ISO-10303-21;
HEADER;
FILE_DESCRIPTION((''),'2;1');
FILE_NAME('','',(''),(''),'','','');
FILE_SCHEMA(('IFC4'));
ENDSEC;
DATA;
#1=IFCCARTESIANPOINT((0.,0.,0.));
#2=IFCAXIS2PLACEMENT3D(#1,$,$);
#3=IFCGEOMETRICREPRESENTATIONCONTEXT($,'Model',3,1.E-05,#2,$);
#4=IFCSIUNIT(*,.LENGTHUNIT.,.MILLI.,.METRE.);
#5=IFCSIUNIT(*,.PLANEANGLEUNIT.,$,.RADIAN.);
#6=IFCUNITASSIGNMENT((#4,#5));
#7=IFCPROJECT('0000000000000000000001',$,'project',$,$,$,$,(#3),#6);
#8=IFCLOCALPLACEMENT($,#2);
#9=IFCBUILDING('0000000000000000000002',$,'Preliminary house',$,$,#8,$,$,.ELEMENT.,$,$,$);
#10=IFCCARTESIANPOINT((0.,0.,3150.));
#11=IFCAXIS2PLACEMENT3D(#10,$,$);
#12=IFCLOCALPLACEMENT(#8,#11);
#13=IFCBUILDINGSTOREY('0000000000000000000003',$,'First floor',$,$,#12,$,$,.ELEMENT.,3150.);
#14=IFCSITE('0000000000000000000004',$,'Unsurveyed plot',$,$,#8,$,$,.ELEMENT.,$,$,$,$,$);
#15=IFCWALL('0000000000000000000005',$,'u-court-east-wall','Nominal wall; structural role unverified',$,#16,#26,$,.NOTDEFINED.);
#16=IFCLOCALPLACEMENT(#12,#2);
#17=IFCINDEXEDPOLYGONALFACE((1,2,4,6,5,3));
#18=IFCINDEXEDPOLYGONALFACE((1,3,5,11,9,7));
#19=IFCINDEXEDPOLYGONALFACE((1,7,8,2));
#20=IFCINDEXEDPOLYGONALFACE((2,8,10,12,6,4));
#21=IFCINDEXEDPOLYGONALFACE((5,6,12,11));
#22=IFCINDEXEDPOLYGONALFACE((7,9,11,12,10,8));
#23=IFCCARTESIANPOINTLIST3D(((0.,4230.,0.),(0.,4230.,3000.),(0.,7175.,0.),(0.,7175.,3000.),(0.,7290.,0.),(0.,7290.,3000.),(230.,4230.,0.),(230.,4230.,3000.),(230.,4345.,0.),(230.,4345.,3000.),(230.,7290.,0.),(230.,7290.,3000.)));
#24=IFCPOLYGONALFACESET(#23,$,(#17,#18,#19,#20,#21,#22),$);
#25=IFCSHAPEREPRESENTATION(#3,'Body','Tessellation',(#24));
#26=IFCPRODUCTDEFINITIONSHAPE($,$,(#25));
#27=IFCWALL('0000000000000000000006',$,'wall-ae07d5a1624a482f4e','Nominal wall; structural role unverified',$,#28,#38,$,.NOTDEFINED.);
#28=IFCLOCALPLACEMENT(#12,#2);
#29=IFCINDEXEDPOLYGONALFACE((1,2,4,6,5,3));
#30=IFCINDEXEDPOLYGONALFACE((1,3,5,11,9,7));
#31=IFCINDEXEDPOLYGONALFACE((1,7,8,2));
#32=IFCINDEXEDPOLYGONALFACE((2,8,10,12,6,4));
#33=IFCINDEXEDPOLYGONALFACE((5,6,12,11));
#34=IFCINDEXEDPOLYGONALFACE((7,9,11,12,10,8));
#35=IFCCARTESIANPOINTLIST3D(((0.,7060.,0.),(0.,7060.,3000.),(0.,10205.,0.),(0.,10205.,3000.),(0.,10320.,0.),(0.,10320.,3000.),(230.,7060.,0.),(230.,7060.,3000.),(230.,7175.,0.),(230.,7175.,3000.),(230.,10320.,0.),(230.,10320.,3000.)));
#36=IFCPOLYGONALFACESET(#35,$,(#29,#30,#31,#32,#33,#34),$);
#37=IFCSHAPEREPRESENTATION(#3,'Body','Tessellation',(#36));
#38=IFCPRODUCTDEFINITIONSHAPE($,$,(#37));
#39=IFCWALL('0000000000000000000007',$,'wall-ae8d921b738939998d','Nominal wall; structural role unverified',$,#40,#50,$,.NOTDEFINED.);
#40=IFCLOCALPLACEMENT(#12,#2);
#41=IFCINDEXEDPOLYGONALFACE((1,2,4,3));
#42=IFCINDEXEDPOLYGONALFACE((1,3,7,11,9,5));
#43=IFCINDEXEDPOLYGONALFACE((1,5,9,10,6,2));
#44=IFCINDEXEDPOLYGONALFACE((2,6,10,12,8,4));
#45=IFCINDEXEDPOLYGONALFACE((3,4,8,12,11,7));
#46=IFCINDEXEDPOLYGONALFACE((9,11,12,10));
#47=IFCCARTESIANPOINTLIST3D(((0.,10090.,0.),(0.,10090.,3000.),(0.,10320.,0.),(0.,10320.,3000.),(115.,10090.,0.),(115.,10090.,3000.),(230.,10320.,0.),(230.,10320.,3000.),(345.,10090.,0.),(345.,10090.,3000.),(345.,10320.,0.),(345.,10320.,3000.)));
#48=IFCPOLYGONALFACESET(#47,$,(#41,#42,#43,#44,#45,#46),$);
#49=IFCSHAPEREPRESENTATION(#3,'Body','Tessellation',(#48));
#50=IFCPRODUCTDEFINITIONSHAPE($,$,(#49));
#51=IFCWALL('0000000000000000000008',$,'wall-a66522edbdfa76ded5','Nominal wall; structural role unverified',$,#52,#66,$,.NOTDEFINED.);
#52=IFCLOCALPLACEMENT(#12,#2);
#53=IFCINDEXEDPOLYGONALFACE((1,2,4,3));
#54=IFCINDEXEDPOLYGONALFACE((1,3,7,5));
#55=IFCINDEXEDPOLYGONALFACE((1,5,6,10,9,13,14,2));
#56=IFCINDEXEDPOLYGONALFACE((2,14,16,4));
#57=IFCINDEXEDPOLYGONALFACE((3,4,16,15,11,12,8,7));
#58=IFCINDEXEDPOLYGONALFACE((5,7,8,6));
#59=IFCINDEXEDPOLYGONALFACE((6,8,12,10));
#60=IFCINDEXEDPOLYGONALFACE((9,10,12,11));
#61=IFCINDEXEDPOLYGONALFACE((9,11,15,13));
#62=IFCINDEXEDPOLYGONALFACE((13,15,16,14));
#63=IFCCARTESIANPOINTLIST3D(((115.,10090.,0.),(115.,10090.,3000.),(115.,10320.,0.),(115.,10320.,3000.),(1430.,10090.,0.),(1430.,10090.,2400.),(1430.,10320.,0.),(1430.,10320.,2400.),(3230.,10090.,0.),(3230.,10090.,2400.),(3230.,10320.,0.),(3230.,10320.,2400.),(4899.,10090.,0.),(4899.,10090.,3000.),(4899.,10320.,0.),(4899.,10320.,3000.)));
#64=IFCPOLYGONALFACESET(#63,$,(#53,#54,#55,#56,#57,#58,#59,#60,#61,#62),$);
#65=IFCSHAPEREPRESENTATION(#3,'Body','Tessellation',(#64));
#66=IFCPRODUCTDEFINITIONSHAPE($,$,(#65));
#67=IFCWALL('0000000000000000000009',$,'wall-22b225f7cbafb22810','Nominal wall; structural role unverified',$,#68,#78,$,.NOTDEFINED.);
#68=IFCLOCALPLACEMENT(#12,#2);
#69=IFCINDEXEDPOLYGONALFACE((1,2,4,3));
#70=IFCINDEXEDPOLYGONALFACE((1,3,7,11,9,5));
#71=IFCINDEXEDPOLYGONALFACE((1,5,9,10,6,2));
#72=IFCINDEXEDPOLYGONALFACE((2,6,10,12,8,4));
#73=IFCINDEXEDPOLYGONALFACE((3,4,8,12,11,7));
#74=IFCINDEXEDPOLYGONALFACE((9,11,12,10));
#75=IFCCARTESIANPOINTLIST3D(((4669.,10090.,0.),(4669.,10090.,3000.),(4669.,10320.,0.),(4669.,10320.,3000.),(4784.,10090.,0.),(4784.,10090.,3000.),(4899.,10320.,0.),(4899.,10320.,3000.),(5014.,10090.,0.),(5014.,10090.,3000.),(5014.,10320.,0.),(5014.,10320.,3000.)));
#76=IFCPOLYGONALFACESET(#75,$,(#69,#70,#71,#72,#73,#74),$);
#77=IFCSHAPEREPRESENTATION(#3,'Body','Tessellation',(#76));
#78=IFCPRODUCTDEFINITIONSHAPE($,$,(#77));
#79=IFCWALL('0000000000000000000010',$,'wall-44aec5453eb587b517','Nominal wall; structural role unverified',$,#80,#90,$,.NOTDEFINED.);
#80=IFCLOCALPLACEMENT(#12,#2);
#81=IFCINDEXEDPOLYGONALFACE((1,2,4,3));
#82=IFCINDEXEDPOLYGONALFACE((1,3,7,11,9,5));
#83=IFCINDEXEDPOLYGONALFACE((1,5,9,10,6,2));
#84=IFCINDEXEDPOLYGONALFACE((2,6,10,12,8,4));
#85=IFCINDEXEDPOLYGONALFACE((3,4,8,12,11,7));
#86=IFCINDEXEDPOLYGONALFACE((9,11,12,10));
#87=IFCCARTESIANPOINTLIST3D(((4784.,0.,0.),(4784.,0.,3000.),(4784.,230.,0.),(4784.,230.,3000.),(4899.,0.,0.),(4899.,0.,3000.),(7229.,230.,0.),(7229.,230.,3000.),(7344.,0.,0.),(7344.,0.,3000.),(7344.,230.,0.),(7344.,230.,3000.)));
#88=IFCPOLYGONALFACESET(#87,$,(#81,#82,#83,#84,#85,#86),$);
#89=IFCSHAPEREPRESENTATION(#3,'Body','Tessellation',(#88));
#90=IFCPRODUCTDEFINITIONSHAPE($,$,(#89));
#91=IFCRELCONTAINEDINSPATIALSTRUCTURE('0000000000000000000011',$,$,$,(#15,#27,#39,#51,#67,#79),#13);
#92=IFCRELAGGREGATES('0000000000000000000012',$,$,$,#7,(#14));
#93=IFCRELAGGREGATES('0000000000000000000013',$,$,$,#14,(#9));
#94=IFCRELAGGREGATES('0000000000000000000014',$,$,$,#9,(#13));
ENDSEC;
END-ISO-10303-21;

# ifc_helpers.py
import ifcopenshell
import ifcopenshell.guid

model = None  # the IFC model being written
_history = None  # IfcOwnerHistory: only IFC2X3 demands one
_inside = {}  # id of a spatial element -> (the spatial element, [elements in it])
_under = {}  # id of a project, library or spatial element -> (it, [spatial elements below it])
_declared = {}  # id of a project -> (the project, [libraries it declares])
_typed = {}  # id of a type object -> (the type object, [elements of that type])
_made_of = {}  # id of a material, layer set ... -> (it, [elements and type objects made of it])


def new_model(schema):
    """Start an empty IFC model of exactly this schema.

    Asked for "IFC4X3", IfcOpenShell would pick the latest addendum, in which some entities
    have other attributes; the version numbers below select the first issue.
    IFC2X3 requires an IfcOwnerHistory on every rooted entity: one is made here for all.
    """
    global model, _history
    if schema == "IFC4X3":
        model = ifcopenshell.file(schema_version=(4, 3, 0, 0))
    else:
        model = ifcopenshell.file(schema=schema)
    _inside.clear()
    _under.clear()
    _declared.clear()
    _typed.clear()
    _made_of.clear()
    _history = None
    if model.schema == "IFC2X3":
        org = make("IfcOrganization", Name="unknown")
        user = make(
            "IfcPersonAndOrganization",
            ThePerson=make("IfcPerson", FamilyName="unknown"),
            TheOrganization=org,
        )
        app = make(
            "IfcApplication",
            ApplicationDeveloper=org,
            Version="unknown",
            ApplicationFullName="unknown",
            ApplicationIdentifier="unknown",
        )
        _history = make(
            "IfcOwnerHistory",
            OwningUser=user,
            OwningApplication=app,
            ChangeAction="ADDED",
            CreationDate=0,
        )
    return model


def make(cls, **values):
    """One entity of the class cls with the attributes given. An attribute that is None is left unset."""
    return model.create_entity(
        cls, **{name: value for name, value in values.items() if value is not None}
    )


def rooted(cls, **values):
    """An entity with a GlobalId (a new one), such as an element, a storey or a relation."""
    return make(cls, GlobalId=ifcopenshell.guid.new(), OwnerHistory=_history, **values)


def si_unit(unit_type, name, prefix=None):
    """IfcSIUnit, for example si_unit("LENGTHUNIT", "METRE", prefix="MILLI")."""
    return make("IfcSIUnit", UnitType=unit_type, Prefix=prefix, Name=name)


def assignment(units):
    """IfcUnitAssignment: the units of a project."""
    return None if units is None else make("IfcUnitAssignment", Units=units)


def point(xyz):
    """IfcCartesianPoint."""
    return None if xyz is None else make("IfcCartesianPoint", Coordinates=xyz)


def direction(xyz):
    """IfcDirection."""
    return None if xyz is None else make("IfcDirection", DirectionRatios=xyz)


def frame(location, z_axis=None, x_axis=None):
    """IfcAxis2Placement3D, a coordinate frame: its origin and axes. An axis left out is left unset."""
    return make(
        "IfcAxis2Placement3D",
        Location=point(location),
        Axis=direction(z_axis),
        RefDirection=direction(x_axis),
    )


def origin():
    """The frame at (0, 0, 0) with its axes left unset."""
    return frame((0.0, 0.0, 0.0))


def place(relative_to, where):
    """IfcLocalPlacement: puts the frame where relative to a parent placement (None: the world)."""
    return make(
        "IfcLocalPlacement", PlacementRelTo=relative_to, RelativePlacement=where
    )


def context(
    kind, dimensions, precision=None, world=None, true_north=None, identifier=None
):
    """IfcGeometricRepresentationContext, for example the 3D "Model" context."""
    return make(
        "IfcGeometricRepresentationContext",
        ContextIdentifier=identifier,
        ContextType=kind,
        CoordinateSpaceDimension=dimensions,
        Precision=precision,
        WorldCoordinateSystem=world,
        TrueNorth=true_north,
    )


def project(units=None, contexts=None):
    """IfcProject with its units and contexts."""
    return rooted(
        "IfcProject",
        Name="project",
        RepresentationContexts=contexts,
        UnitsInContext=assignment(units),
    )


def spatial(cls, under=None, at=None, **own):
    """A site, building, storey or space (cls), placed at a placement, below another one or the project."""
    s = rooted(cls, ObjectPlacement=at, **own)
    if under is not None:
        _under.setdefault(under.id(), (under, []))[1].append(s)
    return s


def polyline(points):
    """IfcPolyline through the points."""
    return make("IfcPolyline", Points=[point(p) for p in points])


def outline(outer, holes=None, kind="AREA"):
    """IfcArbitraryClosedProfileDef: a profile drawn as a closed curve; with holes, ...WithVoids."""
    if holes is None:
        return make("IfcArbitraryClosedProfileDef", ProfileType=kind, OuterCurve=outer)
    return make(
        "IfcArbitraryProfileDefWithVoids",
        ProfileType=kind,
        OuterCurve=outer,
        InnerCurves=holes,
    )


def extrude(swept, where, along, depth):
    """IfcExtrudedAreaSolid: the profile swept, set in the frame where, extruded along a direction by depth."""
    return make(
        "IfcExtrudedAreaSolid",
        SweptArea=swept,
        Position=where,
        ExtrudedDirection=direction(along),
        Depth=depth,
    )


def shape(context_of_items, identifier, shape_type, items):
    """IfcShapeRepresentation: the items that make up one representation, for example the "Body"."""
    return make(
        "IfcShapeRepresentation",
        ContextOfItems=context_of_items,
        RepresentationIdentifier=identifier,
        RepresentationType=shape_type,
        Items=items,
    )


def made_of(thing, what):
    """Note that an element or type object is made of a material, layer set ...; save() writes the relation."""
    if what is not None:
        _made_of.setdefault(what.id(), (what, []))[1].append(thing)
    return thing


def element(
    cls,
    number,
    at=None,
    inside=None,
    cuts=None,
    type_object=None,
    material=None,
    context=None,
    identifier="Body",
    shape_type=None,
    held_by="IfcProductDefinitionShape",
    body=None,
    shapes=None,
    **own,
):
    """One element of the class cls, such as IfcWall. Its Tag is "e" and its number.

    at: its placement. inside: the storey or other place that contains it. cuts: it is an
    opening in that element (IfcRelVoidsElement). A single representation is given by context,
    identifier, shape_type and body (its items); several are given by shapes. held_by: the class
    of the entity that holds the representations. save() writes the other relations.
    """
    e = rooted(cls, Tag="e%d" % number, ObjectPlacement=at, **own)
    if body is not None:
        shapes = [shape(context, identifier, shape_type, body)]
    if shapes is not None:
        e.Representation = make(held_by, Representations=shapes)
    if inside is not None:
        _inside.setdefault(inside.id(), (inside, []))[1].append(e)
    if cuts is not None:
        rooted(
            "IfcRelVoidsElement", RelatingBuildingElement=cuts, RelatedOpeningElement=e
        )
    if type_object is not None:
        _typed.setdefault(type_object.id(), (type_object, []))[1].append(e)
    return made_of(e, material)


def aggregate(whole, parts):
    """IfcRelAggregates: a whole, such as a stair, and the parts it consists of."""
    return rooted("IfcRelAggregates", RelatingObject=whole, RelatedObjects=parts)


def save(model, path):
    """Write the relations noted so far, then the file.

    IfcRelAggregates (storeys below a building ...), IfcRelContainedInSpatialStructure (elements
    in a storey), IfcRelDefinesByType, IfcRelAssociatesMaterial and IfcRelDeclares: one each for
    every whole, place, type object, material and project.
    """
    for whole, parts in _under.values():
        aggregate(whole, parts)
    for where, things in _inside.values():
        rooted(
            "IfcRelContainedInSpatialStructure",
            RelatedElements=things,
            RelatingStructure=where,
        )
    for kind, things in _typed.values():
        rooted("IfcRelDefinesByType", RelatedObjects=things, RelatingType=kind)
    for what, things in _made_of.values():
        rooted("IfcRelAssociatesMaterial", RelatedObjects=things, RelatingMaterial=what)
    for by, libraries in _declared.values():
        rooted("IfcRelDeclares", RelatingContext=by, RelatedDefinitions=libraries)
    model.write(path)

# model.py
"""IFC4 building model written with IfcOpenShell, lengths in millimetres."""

from ifc_helpers import new_model, si_unit, frame, origin, place, context, project, spatial, polyline, outline, extrude, element, save


model = new_model("IFC4")

# Units and contexts
model_context = context("Model", 3, precision=1e-05, world=origin())
ifc_project = project(units=[si_unit("LENGTHUNIT", "METRE", prefix="MILLI"), si_unit("PLANEANGLEUNIT", "RADIAN")], contexts=[model_context])

# Site, building, storey
placement_1 = place(None, origin())
site = spatial("IfcSite", under=ifc_project, at=placement_1, Name="Unsurveyed plot", CompositionType="ELEMENT")
building = spatial("IfcBuilding", under=site, at=placement_1, Name="Preliminary house", CompositionType="ELEMENT")
placement_2 = place(placement_1, frame((0.0, 0.0, 3150.0)))
storey = spatial("IfcBuildingStorey", under=building, at=placement_2, Name="First floor", CompositionType="ELEMENT", Elevation=3150.0)

# Wall
element("IfcWall", 1, at=placement_2, inside=storey, Name="u-court-east-wall", Description="Nominal wall; structural role unverified", PredefinedType="NOTDEFINED", context=model_context, shape_type="SweptSolid", body=[
    extrude(outline(polyline([(0.0, 7175.0), (0.0, 7290.0), (230.0, 7290.0), (230.0, 4345.0), (230.0, 4230.0), (0.0, 4230.0), (0.0, 7175.0)])), origin(), (0.0, 0.0, 1.0), 3000.0),
])

# Wall
element("IfcWall", 2, at=placement_2, inside=storey, Name="wall-ae07d5a1624a482f4e", Description="Nominal wall; structural role unverified", PredefinedType="NOTDEFINED", context=model_context, shape_type="SweptSolid", body=[
    extrude(outline(polyline([(0.0, 10205.0), (0.0, 10320.0), (230.0, 10320.0), (230.0, 7175.0), (230.0, 7060.0), (0.0, 7060.0), (0.0, 10205.0)])), origin(), (0.0, 0.0, 1.0), 3000.0),
])

# Wall
element("IfcWall", 3, at=placement_2, inside=storey, Name="wall-ae8d921b738939998d", Description="Nominal wall; structural role unverified", PredefinedType="NOTDEFINED", context=model_context, shape_type="SweptSolid", body=[
    extrude(outline(polyline([(230.0, 10320.0), (345.0, 10320.0), (345.0, 10090.0), (115.0, 10090.0), (0.0, 10090.0), (0.0, 10320.0), (230.0, 10320.0)])), origin(), (0.0, 0.0, 1.0), 3000.0),
])

# Wall, opening
wall_1 = element("IfcWall", 4, at=placement_2, inside=storey, Name="wall-a66522edbdfa76ded5", Description="Nominal wall; structural role unverified", PredefinedType="NOTDEFINED", context=model_context, shape_type="SweptSolid", body=[
    extrude(outline(polyline([(4784.0, 10320.0), (4899.0, 10320.0), (4899.0, 10090.0), (230.0, 10090.0), (115.0, 10090.0), (115.0, 10320.0), (4784.0, 10320.0)])), origin(), (0.0, 0.0, 1.0), 3000.0),
])
element("IfcOpeningElement", 5, at=placement_2, cuts=wall_1, PredefinedType="OPENING", context=model_context, shape_type="SweptSolid", body=[
    extrude(outline(polyline([(1430.0, 9675.0), (3230.0, 9675.0), (3230.0, 10735.0), (1430.0, 10735.0), (1430.0, 9675.0)])), origin(), (0.0, 0.0, 1.0), 2400.0),
])

# Wall
element("IfcWall", 6, at=placement_2, inside=storey, Name="wall-22b225f7cbafb22810", Description="Nominal wall; structural role unverified", PredefinedType="NOTDEFINED", context=model_context, shape_type="SweptSolid", body=[
    extrude(outline(polyline([(4899.0, 10320.0), (5014.0, 10320.0), (5014.0, 10090.0), (4784.0, 10090.0), (4669.0, 10090.0), (4669.0, 10320.0), (4899.0, 10320.0)])), origin(), (0.0, 0.0, 1.0), 3000.0),
])

# Wall
element("IfcWall", 7, at=placement_2, inside=storey, Name="wall-44aec5453eb587b517", Description="Nominal wall; structural role unverified", PredefinedType="NOTDEFINED", context=model_context, shape_type="SweptSolid", body=[
    extrude(outline(polyline([(7229.0, 230.0), (7344.0, 230.0), (7344.0, 0.0), (4899.0, 0.0), (4784.0, 0.0), (4784.0, 230.0), (7229.0, 230.0)])), origin(), (0.0, 0.0, 1.0), 3000.0),
])

save(model, "model.ifc")
